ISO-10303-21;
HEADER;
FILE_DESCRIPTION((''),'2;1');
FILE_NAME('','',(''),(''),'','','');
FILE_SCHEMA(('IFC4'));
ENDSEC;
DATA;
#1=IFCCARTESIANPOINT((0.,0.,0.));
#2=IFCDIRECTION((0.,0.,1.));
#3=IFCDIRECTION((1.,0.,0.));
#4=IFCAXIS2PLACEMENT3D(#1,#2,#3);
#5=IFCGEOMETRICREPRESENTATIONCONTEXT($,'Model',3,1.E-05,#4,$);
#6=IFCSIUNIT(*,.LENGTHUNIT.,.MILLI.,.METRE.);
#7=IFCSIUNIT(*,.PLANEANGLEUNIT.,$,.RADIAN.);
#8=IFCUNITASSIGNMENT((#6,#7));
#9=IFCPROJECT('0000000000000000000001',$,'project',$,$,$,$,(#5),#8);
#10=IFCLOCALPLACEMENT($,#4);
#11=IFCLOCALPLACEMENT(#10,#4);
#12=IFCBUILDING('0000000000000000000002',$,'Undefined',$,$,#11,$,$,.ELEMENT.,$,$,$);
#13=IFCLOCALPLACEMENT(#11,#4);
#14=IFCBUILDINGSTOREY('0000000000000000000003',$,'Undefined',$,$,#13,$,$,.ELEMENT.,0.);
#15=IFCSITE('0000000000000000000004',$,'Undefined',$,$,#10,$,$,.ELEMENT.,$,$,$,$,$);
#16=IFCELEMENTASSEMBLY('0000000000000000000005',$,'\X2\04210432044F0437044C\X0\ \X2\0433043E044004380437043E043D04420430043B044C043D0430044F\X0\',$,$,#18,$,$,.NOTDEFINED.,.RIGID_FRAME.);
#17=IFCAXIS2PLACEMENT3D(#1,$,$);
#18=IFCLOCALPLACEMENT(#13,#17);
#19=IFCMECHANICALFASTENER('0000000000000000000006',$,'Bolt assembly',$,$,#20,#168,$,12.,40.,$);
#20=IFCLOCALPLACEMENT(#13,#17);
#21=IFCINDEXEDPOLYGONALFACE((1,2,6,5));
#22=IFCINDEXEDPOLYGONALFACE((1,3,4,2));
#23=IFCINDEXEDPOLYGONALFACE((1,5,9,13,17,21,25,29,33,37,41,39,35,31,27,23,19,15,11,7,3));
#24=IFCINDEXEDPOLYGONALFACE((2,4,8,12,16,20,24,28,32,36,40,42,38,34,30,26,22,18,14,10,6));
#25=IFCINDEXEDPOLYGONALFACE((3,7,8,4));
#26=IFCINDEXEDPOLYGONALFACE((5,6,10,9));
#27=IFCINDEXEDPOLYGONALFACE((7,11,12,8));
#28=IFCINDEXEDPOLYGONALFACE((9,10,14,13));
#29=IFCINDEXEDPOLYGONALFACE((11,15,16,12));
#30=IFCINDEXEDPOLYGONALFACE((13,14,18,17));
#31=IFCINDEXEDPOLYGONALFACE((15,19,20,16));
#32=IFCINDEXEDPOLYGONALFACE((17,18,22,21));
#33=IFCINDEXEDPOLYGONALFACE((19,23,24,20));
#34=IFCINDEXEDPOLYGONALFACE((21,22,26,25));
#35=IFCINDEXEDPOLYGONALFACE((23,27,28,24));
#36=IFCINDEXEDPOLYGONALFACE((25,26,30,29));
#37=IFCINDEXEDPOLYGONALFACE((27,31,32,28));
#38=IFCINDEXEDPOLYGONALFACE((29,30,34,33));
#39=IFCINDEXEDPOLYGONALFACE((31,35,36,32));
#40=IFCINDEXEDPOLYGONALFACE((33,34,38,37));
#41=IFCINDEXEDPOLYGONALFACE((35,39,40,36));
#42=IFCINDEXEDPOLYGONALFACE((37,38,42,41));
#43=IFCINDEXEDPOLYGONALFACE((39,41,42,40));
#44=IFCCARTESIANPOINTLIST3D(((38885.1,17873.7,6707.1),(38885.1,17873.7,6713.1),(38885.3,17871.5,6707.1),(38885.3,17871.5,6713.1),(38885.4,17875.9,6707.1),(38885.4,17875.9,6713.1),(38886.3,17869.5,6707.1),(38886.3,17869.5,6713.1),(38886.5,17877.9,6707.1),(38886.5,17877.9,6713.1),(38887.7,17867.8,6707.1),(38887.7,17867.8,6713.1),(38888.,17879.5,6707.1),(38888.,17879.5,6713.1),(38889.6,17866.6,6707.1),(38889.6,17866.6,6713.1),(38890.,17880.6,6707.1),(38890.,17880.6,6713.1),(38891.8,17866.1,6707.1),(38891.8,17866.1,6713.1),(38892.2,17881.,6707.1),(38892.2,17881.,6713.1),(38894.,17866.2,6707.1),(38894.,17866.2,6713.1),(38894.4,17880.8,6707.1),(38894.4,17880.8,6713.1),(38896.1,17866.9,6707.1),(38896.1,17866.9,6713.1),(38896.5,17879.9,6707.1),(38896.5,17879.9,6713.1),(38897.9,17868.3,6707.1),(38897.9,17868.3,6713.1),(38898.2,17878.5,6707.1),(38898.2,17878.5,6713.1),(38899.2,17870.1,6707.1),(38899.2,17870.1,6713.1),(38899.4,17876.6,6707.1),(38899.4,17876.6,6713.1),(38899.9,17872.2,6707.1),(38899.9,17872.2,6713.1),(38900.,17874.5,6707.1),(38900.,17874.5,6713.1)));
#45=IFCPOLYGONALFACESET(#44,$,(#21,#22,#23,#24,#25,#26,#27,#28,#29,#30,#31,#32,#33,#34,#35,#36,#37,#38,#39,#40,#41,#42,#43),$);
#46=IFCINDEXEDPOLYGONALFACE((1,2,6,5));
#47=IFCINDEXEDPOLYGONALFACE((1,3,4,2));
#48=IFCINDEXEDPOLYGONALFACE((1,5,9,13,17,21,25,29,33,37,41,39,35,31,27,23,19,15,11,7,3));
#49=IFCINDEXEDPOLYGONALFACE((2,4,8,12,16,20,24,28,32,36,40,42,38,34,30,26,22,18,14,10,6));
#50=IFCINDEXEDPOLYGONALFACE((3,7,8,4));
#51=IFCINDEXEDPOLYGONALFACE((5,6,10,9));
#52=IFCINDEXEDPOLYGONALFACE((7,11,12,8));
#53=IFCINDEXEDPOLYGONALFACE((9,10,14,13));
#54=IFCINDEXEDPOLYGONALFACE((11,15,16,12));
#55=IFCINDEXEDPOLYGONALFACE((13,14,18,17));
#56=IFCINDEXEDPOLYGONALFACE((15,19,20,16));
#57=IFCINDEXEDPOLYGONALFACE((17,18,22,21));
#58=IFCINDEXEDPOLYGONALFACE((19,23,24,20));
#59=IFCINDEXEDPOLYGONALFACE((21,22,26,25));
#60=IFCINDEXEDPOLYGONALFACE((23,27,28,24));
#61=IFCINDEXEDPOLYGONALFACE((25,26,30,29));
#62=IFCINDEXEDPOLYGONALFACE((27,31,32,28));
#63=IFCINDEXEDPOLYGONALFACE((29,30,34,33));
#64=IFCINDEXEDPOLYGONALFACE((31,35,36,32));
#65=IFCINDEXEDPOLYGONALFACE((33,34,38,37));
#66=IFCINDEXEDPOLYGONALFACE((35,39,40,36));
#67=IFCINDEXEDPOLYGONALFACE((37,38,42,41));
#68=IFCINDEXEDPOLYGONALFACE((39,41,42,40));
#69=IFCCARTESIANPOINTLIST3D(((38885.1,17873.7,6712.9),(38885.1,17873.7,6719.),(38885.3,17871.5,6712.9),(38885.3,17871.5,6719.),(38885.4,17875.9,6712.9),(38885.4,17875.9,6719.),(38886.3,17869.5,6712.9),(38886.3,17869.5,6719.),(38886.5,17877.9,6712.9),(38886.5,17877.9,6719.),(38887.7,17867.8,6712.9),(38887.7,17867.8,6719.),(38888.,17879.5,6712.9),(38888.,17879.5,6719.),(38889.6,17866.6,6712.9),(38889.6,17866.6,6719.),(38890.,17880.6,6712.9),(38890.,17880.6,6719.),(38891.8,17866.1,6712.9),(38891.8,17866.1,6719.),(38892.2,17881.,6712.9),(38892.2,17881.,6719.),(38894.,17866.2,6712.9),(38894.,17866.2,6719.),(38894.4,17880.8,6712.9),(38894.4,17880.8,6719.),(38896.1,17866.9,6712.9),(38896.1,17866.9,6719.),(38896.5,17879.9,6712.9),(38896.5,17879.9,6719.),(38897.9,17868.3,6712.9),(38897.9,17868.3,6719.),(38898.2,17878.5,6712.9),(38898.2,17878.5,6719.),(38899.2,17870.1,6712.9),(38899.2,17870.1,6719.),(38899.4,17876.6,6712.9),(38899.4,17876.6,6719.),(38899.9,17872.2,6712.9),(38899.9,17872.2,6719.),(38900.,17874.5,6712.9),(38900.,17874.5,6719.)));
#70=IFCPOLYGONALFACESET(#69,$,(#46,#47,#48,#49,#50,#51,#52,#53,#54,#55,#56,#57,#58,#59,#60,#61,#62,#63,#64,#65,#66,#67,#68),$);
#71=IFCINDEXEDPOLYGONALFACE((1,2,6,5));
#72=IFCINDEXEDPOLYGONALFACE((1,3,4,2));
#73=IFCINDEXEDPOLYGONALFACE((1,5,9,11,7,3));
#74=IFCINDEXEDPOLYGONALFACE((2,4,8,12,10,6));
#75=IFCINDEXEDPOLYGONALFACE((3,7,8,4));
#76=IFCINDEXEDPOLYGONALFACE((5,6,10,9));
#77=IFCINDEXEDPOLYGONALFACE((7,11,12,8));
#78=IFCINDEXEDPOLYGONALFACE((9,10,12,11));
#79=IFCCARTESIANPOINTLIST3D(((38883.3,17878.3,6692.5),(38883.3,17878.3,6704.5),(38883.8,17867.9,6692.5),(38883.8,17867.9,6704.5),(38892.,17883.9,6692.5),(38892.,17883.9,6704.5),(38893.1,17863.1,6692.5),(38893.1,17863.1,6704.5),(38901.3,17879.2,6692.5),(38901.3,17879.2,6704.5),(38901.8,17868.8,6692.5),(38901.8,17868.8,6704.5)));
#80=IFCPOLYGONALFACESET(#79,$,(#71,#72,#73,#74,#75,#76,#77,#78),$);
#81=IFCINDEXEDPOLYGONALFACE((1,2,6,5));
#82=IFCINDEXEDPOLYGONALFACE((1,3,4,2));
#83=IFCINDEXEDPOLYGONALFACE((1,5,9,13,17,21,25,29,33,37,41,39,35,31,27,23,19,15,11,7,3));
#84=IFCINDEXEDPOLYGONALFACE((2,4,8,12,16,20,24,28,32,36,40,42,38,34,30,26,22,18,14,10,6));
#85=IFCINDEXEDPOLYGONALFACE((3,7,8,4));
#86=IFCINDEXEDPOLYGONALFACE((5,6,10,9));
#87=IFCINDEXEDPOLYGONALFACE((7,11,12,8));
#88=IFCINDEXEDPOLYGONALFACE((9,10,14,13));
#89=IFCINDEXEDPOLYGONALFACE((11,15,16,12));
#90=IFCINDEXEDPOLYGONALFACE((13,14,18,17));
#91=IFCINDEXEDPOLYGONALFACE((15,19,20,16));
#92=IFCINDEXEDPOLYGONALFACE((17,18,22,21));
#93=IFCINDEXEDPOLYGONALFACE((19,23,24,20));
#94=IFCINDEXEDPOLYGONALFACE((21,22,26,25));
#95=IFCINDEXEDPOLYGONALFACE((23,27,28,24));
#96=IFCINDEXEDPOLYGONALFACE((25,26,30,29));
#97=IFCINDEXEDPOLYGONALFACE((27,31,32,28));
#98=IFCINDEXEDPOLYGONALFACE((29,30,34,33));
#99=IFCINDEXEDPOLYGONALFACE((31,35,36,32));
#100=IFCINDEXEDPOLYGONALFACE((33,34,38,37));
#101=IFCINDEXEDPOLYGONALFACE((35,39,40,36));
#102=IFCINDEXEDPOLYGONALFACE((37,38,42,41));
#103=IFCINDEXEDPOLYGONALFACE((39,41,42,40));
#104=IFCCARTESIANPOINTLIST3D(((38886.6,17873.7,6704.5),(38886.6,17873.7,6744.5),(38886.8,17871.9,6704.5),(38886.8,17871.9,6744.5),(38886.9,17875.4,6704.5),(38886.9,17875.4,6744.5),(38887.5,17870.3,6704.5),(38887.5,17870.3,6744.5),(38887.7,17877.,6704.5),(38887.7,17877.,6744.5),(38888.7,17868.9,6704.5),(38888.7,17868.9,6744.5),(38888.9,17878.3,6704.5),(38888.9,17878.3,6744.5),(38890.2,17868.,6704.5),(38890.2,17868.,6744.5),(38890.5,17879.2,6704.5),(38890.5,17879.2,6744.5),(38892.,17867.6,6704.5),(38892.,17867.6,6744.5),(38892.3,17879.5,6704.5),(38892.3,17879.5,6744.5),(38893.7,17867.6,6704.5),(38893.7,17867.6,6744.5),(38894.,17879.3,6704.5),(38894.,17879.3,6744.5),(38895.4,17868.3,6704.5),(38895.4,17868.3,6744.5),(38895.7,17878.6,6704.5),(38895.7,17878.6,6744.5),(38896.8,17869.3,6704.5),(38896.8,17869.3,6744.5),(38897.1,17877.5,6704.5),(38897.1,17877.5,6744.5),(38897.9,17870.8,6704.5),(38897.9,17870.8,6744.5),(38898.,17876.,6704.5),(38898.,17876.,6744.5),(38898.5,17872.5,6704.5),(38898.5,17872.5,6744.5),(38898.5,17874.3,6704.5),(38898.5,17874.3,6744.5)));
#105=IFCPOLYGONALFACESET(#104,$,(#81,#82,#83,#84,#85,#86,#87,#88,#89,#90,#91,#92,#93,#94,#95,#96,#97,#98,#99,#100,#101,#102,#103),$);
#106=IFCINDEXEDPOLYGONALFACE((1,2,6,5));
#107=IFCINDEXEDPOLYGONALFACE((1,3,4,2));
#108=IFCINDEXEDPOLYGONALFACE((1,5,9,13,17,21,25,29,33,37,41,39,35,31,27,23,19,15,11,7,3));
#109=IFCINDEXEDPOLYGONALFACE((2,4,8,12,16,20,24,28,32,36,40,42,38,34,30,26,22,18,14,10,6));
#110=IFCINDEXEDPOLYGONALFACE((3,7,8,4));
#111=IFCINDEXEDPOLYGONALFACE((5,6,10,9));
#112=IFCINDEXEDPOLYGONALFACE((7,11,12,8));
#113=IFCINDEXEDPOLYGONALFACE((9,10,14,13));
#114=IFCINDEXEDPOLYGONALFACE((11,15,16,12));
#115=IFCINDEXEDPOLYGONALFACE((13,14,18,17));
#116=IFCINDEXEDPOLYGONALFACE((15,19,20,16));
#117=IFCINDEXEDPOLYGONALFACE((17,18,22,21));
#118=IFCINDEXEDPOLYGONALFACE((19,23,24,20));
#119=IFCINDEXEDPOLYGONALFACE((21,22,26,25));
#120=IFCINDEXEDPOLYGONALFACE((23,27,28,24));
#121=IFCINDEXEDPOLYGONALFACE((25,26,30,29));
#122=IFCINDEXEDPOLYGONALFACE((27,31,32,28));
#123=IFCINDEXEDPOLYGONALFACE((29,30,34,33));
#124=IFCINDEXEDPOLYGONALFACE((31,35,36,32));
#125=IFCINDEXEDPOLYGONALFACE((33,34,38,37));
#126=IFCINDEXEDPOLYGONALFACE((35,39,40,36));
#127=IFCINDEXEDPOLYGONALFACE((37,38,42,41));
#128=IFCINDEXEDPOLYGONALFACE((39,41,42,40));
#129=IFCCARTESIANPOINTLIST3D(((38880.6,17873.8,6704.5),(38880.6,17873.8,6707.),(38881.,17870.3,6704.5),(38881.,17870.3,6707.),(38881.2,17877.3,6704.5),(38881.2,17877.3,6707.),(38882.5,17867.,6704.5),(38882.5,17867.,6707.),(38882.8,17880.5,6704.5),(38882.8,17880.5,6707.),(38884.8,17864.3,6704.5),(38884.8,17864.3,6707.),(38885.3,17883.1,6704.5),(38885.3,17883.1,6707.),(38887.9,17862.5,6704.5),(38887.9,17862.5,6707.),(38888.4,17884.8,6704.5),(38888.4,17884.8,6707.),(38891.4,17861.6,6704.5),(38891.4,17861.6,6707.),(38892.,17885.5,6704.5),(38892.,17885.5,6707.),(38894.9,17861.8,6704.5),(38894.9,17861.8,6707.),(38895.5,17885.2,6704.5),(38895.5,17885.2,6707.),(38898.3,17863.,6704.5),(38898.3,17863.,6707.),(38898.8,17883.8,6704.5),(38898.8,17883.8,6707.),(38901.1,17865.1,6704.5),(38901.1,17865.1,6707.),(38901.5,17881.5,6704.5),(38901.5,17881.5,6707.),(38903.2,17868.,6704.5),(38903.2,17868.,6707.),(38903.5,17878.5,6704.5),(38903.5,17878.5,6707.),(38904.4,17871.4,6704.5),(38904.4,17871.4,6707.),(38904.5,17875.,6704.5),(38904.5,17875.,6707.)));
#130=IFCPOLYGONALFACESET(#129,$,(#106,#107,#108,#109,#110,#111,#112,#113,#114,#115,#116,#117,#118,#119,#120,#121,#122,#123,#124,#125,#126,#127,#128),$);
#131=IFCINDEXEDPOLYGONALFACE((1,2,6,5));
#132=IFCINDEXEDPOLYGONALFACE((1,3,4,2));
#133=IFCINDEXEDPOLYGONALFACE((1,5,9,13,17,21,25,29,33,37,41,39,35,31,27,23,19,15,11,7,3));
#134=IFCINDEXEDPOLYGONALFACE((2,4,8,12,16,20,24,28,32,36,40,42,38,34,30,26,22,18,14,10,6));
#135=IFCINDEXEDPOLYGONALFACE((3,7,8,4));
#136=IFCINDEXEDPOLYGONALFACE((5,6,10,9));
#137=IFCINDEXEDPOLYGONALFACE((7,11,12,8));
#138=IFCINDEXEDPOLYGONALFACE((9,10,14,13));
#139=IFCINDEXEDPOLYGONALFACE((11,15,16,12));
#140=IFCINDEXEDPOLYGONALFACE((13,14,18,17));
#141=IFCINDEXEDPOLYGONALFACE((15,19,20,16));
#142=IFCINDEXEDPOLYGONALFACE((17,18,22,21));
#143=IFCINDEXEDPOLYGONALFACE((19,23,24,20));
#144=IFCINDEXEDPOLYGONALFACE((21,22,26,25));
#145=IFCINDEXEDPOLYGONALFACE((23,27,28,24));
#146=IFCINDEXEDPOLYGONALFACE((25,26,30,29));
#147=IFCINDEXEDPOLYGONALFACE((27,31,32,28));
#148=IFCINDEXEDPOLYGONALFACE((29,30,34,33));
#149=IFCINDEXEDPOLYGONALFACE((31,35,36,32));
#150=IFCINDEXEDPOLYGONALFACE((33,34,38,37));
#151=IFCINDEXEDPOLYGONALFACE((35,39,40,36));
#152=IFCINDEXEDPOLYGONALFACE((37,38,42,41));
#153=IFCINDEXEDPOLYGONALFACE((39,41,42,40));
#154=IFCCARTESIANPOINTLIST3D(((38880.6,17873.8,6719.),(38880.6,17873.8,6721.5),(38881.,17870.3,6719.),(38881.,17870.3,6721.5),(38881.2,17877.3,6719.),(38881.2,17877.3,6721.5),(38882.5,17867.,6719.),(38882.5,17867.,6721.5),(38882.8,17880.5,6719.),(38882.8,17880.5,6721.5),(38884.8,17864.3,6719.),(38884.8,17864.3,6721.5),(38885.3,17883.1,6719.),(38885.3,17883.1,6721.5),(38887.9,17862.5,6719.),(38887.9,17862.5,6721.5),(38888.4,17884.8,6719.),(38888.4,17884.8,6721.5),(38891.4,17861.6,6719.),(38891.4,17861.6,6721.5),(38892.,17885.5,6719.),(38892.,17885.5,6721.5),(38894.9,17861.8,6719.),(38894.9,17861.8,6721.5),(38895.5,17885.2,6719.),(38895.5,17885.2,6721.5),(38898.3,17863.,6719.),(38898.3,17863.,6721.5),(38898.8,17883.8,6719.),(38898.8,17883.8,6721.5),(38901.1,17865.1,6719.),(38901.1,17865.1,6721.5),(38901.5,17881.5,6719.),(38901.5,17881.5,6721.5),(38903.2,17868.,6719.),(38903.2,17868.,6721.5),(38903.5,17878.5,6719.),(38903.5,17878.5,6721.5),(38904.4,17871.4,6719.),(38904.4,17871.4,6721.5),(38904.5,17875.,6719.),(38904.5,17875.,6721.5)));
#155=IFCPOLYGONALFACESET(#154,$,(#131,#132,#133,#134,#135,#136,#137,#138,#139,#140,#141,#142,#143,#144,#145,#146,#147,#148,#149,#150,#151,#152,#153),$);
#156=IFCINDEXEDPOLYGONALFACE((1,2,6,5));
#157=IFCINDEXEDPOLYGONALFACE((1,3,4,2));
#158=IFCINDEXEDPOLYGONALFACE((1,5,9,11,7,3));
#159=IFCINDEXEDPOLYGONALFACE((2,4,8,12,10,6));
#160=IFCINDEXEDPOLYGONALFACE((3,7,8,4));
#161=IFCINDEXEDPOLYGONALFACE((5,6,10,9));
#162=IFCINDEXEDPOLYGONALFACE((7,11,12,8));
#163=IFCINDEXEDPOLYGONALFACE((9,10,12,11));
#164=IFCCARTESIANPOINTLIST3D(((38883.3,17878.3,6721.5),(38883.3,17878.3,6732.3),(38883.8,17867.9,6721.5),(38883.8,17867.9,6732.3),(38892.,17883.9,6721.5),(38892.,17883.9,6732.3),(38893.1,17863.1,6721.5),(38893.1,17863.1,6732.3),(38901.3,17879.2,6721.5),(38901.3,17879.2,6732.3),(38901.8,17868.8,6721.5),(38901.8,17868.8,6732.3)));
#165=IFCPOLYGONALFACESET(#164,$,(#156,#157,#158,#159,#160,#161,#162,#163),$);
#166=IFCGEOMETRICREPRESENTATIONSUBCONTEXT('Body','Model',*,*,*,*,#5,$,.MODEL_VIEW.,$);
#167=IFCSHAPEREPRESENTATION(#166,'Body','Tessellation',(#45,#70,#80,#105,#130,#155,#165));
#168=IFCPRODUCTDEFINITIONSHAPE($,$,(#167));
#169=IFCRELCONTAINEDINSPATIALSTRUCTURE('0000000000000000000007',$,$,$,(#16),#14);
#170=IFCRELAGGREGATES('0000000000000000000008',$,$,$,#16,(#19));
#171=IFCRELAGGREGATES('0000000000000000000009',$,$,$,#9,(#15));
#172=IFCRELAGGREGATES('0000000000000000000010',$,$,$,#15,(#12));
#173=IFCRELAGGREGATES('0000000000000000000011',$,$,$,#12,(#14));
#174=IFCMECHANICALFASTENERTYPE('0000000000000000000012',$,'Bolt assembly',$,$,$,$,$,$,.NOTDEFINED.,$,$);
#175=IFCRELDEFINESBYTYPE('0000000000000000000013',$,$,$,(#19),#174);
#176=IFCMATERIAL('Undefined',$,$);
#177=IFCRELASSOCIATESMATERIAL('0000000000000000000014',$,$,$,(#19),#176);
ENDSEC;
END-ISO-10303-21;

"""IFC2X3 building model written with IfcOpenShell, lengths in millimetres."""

from ifc_helpers import new_model, si_unit, frame, origin_with_axes, origin_2d_with_axis, place, context, subcontext, project, spatial, polyline, circle, outline, extrude, source, transform, mapped, material, type_object, element, aggregate, save


model = new_model("IFC2X3")

# Units and contexts
model_context = context("Model", 3, precision=1e-05, world=origin_with_axes())
body_context = subcontext(model_context, "Body", "Model", "MODEL_VIEW")
ifc_project = project(units=[si_unit("LENGTHUNIT", "METRE", prefix="MILLI"), si_unit("PLANEANGLEUNIT", "RADIAN")], contexts=[model_context])

# Site, building, storey
site_placement = place(None, origin_with_axes())
site = spatial("IfcSite", under=ifc_project, at=site_placement, Name="Undefined", CompositionType="ELEMENT")
building_placement = place(site_placement, origin_with_axes())
building = spatial("IfcBuilding", under=site, at=building_placement, Name="Undefined", CompositionType="ELEMENT")
storey_placement = place(building_placement, origin_with_axes())
storey = spatial("IfcBuildingStorey", under=building, at=storey_placement, Name="Undefined", CompositionType="ELEMENT", Elevation=0.0)

# Element assembly
assembly_1_placement = place(storey_placement, origin_with_axes())
assembly_1 = element("IfcElementAssembly", 1, at=assembly_1_placement, inside=storey, Name="Связь горизонтальная", AssemblyPlace="NOTDEFINED", PredefinedType="RIGID_FRAME")

# Mechanical fastener
ifc_material_1 = material(Name="Undefined")
mechanical_fastener_type = type_object("IfcMechanicalFastenerType", Name="Bolt assembly")
shared_shape_1 = source(origin_with_axes(), body_context, "Body", "SweptSolid", [
    extrude(circle(Radius=7.5, at=origin_2d_with_axis()), frame((0.0, 0.1, 0.0), z_axis=(0.0, 1.0, 0.0), x_axis=(1.0, 0.0, 0.0)), (0.0, 0.0, 1.0), 6.0),
    extrude(circle(Radius=7.5, at=origin_2d_with_axis()), frame((0.0, 5.9, 0.0), z_axis=(0.0, 1.0, 0.0), x_axis=(1.0, 0.0, 0.0)), (0.0, 0.0, 1.0), 6.1),
    extrude(outline(polyline([(10.4, 0.0), (5.2, 9.0), (-5.2, 9.0), (-10.4, 0.0), (-5.2, -9.0), (5.2, -9.0), (10.4, 0.0)])), frame((0.0, -14.5, 0.0), z_axis=(0.0, 1.0, 0.0), x_axis=(1.0, 0.0, 0.0)), (0.0, 0.0, 1.0), 12.0),
    extrude(circle(Radius=6.0, at=origin_2d_with_axis()), frame((0.0, -2.5, 0.0), z_axis=(0.0, 1.0, 0.0), x_axis=(1.0, 0.0, 0.0)), (0.0, 0.0, 1.0), 40.0),
    extrude(circle(Radius=12.0, at=origin_2d_with_axis()), frame((0.0, -2.5, 0.0), z_axis=(0.0, 1.0, 0.0), x_axis=(1.0, 0.0, 0.0)), (0.0, 0.0, 1.0), 2.5),
    extrude(circle(Radius=12.0, at=origin_2d_with_axis()), frame((0.0, 12.0, 0.0), z_axis=(0.0, 1.0, 0.0), x_axis=(1.0, 0.0, 0.0)), (0.0, 0.0, 1.0), 2.5),
    extrude(outline(polyline([(10.4, 0.0), (5.2, 9.0), (-5.2, 9.0), (-10.4, 0.0), (-5.2, -9.0), (5.2, -9.0), (10.4, 0.0)])), frame((0.0, 14.5, 0.0), z_axis=(0.0, 1.0, 0.0), x_axis=(1.0, 0.0, 0.0)), (0.0, 0.0, 1.0), 10.8),
])
mechanical_fastener_1_placement = place(assembly_1_placement, frame((38892.6, 17873.5, 6707.0), z_axis=(-0.542525, 0.840039, 0.0), x_axis=(-0.840039, -0.542525, 0.0)))
mechanical_fastener_1 = element("IfcMechanicalFastener", 2, at=mechanical_fastener_1_placement, type_object=mechanical_fastener_type, material=ifc_material_1, Name="Bolt assembly", NominalDiameter=12.0, NominalLength=40.0, context=body_context, shape_type="MappedRepresentation", body=[
    mapped(shared_shape_1, transform((0.0, 0.0, 0.0))),
])
aggregate(assembly_1, [mechanical_fastener_1])

save(model, "model.ifc")
